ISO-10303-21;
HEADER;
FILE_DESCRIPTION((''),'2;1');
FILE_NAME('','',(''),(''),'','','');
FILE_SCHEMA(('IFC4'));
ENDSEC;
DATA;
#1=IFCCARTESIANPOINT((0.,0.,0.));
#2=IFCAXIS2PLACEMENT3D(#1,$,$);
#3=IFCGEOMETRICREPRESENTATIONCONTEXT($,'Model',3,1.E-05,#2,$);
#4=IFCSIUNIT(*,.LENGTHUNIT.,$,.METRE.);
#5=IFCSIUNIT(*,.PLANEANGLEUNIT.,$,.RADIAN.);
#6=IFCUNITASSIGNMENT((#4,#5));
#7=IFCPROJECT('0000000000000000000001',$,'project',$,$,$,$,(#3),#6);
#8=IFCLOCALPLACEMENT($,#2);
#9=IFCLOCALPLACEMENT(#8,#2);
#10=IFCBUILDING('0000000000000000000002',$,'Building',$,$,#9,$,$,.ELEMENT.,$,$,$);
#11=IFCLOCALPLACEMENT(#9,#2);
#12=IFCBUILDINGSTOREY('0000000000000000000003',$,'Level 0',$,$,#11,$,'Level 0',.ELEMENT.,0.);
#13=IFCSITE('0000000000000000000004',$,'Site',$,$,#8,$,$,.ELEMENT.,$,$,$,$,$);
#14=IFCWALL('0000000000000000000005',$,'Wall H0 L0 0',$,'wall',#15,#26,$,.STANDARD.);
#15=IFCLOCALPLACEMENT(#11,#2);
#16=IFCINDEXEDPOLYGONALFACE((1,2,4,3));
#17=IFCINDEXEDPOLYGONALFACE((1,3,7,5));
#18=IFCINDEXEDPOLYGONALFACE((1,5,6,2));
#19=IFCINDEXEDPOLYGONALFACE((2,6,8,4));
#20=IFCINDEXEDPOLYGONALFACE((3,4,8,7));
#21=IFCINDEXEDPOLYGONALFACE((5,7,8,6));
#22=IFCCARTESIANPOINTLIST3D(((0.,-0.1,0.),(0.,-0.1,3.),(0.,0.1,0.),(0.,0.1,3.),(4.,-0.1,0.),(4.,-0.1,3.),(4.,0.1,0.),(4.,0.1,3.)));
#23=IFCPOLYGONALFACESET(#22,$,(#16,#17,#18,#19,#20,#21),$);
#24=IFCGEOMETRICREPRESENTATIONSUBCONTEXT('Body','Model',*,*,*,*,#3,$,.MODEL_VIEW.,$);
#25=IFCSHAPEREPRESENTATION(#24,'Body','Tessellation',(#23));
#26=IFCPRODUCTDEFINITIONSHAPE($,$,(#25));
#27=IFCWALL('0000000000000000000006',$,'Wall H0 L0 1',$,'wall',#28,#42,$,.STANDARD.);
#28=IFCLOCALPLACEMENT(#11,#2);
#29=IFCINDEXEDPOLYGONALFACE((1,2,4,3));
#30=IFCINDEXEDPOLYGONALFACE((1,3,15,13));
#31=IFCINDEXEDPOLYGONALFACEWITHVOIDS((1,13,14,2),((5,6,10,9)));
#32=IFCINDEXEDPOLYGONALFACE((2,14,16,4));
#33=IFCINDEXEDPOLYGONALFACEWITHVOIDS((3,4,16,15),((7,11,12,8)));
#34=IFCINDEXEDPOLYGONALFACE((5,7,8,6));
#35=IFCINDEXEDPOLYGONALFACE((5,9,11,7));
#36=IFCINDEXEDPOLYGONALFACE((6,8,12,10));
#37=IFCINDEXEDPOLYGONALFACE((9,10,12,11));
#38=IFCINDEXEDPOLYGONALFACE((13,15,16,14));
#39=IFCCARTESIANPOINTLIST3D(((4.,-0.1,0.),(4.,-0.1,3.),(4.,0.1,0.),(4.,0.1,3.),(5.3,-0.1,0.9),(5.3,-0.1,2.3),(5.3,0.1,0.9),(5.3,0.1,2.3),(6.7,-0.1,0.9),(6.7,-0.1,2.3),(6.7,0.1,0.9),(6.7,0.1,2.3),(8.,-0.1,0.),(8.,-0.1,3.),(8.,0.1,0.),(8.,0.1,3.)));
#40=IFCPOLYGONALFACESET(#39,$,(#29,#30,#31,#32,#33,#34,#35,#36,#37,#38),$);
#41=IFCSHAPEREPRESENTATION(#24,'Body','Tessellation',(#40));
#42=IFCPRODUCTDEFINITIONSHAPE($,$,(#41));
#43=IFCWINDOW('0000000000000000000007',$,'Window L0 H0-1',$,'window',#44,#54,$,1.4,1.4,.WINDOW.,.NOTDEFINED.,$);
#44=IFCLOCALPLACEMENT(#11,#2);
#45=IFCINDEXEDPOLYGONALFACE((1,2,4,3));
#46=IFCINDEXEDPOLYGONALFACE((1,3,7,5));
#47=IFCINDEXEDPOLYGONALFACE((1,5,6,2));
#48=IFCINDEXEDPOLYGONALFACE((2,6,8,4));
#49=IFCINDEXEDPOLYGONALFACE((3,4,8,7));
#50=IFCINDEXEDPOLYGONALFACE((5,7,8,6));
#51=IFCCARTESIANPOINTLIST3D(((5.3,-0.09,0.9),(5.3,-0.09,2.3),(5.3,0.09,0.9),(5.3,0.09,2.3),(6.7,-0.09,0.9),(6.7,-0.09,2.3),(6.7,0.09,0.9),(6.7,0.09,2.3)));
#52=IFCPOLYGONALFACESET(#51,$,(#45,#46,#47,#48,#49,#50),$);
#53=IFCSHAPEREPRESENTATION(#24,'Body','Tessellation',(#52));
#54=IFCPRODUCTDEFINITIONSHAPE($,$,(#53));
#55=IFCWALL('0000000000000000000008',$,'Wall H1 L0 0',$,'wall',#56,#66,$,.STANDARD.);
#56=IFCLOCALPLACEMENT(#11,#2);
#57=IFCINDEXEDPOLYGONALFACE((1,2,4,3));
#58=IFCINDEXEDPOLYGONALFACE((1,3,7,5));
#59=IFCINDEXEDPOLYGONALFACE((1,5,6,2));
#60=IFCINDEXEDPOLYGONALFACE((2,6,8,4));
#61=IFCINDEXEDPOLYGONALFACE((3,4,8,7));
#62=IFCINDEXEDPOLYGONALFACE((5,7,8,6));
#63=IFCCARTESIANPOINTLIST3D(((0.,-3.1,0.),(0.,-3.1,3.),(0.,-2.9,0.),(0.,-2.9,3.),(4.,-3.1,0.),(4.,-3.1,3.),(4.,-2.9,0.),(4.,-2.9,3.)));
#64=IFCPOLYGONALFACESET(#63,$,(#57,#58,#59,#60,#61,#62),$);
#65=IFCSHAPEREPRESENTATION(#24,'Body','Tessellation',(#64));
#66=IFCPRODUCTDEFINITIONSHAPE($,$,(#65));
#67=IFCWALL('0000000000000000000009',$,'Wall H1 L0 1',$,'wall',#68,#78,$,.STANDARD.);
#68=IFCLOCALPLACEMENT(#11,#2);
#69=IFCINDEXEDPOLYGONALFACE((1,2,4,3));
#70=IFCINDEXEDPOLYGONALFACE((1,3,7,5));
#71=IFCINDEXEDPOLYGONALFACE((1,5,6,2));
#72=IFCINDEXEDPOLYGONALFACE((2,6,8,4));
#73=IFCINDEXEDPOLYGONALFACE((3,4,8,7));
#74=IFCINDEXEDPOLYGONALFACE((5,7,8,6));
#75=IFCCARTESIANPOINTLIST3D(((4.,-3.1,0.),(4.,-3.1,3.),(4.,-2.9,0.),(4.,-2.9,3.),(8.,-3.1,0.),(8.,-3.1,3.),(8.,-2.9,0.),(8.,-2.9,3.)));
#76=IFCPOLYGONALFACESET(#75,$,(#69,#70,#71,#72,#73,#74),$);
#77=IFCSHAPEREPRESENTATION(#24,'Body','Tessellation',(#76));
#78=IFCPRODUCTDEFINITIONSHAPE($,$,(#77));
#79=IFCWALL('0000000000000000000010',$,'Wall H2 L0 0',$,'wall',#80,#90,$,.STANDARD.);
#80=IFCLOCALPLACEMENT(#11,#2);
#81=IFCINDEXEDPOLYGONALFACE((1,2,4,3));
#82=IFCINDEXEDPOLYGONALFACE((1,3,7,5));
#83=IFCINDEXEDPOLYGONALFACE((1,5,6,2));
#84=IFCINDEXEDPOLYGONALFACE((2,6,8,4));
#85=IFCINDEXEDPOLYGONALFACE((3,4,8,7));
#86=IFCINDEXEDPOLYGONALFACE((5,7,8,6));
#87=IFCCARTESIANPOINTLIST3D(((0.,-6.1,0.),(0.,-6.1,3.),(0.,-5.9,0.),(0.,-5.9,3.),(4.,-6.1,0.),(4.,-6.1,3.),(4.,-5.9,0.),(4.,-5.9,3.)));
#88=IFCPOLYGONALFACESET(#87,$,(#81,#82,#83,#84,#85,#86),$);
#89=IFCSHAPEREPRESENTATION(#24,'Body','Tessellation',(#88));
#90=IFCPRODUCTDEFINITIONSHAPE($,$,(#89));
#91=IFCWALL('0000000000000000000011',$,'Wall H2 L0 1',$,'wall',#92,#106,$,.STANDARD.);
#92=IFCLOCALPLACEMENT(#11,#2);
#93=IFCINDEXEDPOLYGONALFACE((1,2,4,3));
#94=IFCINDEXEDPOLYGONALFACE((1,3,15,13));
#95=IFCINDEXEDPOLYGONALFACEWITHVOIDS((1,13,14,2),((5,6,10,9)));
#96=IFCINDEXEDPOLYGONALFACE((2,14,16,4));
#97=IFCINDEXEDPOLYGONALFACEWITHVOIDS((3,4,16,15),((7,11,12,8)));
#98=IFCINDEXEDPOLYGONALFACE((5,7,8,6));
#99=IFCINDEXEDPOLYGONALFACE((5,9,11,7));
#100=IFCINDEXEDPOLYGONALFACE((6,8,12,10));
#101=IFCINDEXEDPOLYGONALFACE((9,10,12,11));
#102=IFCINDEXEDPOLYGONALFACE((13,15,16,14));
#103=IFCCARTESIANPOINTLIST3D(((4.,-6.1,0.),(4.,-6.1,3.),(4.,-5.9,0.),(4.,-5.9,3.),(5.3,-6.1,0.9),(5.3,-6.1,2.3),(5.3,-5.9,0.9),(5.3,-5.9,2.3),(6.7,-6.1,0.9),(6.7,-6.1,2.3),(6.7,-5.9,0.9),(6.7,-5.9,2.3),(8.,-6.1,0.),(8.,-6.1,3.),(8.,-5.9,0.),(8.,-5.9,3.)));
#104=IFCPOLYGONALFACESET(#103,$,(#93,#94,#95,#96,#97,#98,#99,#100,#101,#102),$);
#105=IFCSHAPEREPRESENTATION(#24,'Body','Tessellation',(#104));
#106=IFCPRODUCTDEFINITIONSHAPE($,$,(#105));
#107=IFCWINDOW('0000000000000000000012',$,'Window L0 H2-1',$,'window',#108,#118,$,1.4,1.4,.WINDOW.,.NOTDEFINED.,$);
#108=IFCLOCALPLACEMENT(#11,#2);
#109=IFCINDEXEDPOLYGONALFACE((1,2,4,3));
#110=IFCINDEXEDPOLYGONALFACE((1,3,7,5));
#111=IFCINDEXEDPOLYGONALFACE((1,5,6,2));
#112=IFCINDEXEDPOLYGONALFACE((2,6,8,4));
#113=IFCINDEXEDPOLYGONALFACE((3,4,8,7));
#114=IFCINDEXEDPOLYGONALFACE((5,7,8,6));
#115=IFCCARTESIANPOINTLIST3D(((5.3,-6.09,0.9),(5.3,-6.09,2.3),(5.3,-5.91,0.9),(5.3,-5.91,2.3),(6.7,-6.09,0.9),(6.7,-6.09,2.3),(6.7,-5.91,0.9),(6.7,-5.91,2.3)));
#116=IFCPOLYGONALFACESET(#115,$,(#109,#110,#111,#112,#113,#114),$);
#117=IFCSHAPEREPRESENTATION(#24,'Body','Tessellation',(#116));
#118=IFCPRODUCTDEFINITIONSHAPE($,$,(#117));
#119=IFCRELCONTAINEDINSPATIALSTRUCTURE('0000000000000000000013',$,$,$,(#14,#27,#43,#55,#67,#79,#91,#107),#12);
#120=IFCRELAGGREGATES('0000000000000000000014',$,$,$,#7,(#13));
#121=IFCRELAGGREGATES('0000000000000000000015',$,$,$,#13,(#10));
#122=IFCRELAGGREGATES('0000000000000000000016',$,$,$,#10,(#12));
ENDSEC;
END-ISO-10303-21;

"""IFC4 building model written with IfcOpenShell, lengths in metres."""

from ifc_helpers import new_model, si_unit, frame, frame_2d, origin, origin_with_axes, origin_2d, place, context, subcontext, project, spatial, rectangle, extrude, element, fill, save


model = new_model("IFC4")

# Units and contexts
model_context = context("Model", 3, precision=1e-05, world=origin())
body_context = subcontext(model_context, "Body", "Model", "MODEL_VIEW")
ifc_project = project(units=[si_unit("LENGTHUNIT", "METRE"), si_unit("PLANEANGLEUNIT", "RADIAN")], contexts=[model_context])

# Site, building, storey
site_placement = place(None, origin())
site = spatial("IfcSite", under=ifc_project, at=site_placement, Name="Site", CompositionType="ELEMENT")
building_placement = place(site_placement, origin())
building = spatial("IfcBuilding", under=site, at=building_placement, Name="Building", CompositionType="ELEMENT")
storey_placement = place(building_placement, origin())
storey = spatial("IfcBuildingStorey", under=building, at=storey_placement, Name="Level 0", LongName="Level 0", CompositionType="ELEMENT", Elevation=0.0)

# Wall
wall_1_placement = place(storey_placement, origin_with_axes())
element("IfcWall", 1, at=wall_1_placement, inside=storey, Name="Wall H0 L0 0", ObjectType="wall", PredefinedType="STANDARD", context=body_context, shape_type="SweptSolid", body=[
    extrude(rectangle(XDim=4.0, YDim=0.2, at=frame_2d((2.0, 0.0))), origin(), (0.0, 0.0, 1.0), 3.0),
])

# Wall, opening, window
wall_2_placement = place(storey_placement, frame((4.0, 0.0, 0.0), z_axis=(0.0, 0.0, 1.0), x_axis=(1.0, 0.0, 0.0)))
wall_2 = element("IfcWall", 2, at=wall_2_placement, inside=storey, Name="Wall H0 L0 1", ObjectType="wall", PredefinedType="STANDARD", context=body_context, shape_type="SweptSolid", body=[
    extrude(rectangle(XDim=4.0, YDim=0.2, at=frame_2d((2.0, 0.0))), origin(), (0.0, 0.0, 1.0), 3.0),
])
opening_1_placement = place(storey_placement, frame((6.0, 0.0, 0.9), z_axis=(0.0, 0.0, 1.0), x_axis=(1.0, 0.0, 0.0)))
opening_1 = element("IfcOpeningElement", 3, at=opening_1_placement, cuts=wall_2, ObjectType="Opening", PredefinedType="OPENING", context=body_context, shape_type="SweptSolid", body=[
    extrude(rectangle(XDim=1.4, YDim=0.22, at=origin_2d()), origin(), (0.0, 0.0, 1.0), 1.4),
])
window_1_placement = place(storey_placement, frame((6.0, 0.0, 0.9), z_axis=(0.0, 0.0, 1.0), x_axis=(1.0, 0.0, 0.0)))
window_1 = element("IfcWindow", 4, at=window_1_placement, inside=storey, Name="Window L0 H0-1", ObjectType="window", OverallHeight=1.4, OverallWidth=1.4, PartitioningType="NOTDEFINED", PredefinedType="WINDOW", context=body_context, shape_type="SweptSolid", body=[
    extrude(rectangle(XDim=1.4, YDim=0.18, at=origin_2d()), origin(), (0.0, 0.0, 1.0), 1.4),
])
fill(opening_1, window_1)

# Walls
for number, where, z_axis, x_axis, name in (
    (5, (0.0, -3.0, 0.0), (0.0, 0.0, 1.0), (1.0, 0.0, 0.0), "Wall H1 L0 0"),
    (6, (4.0, -3.0, 0.0), (0.0, 0.0, 1.0), (1.0, 0.0, 0.0), "Wall H1 L0 1"),
    (7, (0.0, -6.0, 0.0), (0.0, 0.0, 1.0), (1.0, 0.0, 0.0), "Wall H2 L0 0"),
):
    element("IfcWall", number, at=place(storey_placement, frame(where, z_axis=z_axis, x_axis=x_axis)), inside=storey, Name=name, ObjectType="wall", PredefinedType="STANDARD", context=body_context, shape_type="SweptSolid", body=[
        extrude(rectangle(XDim=4.0, YDim=0.2, at=frame_2d((2.0, 0.0))), origin(), (0.0, 0.0, 1.0), 3.0),
    ])

# Wall, opening, window
wall_3_placement = place(storey_placement, frame((4.0, -6.0, 0.0), z_axis=(0.0, 0.0, 1.0), x_axis=(1.0, 0.0, 0.0)))
wall_3 = element("IfcWall", 8, at=wall_3_placement, inside=storey, Name="Wall H2 L0 1", ObjectType="wall", PredefinedType="STANDARD", context=body_context, shape_type="SweptSolid", body=[
    extrude(rectangle(XDim=4.0, YDim=0.2, at=frame_2d((2.0, 0.0))), origin(), (0.0, 0.0, 1.0), 3.0),
])
opening_2_placement = place(storey_placement, frame((6.0, -6.0, 0.9), z_axis=(0.0, 0.0, 1.0), x_axis=(1.0, 0.0, 0.0)))
opening_2 = element("IfcOpeningElement", 9, at=opening_2_placement, cuts=wall_3, ObjectType="Opening", PredefinedType="OPENING", context=body_context, shape_type="SweptSolid", body=[
    extrude(rectangle(XDim=1.4, YDim=0.22, at=origin_2d()), origin(), (0.0, 0.0, 1.0), 1.4),
])
window_2_placement = place(storey_placement, frame((6.0, -6.0, 0.9), z_axis=(0.0, 0.0, 1.0), x_axis=(1.0, 0.0, 0.0)))
window_2 = element("IfcWindow", 10, at=window_2_placement, inside=storey, Name="Window L0 H2-1", ObjectType="window", OverallHeight=1.4, OverallWidth=1.4, PartitioningType="NOTDEFINED", PredefinedType="WINDOW", context=body_context, shape_type="SweptSolid", body=[
    extrude(rectangle(XDim=1.4, YDim=0.18, at=origin_2d()), origin(), (0.0, 0.0, 1.0), 1.4),
])
fill(opening_2, window_2)

save(model, "model.ifc")
